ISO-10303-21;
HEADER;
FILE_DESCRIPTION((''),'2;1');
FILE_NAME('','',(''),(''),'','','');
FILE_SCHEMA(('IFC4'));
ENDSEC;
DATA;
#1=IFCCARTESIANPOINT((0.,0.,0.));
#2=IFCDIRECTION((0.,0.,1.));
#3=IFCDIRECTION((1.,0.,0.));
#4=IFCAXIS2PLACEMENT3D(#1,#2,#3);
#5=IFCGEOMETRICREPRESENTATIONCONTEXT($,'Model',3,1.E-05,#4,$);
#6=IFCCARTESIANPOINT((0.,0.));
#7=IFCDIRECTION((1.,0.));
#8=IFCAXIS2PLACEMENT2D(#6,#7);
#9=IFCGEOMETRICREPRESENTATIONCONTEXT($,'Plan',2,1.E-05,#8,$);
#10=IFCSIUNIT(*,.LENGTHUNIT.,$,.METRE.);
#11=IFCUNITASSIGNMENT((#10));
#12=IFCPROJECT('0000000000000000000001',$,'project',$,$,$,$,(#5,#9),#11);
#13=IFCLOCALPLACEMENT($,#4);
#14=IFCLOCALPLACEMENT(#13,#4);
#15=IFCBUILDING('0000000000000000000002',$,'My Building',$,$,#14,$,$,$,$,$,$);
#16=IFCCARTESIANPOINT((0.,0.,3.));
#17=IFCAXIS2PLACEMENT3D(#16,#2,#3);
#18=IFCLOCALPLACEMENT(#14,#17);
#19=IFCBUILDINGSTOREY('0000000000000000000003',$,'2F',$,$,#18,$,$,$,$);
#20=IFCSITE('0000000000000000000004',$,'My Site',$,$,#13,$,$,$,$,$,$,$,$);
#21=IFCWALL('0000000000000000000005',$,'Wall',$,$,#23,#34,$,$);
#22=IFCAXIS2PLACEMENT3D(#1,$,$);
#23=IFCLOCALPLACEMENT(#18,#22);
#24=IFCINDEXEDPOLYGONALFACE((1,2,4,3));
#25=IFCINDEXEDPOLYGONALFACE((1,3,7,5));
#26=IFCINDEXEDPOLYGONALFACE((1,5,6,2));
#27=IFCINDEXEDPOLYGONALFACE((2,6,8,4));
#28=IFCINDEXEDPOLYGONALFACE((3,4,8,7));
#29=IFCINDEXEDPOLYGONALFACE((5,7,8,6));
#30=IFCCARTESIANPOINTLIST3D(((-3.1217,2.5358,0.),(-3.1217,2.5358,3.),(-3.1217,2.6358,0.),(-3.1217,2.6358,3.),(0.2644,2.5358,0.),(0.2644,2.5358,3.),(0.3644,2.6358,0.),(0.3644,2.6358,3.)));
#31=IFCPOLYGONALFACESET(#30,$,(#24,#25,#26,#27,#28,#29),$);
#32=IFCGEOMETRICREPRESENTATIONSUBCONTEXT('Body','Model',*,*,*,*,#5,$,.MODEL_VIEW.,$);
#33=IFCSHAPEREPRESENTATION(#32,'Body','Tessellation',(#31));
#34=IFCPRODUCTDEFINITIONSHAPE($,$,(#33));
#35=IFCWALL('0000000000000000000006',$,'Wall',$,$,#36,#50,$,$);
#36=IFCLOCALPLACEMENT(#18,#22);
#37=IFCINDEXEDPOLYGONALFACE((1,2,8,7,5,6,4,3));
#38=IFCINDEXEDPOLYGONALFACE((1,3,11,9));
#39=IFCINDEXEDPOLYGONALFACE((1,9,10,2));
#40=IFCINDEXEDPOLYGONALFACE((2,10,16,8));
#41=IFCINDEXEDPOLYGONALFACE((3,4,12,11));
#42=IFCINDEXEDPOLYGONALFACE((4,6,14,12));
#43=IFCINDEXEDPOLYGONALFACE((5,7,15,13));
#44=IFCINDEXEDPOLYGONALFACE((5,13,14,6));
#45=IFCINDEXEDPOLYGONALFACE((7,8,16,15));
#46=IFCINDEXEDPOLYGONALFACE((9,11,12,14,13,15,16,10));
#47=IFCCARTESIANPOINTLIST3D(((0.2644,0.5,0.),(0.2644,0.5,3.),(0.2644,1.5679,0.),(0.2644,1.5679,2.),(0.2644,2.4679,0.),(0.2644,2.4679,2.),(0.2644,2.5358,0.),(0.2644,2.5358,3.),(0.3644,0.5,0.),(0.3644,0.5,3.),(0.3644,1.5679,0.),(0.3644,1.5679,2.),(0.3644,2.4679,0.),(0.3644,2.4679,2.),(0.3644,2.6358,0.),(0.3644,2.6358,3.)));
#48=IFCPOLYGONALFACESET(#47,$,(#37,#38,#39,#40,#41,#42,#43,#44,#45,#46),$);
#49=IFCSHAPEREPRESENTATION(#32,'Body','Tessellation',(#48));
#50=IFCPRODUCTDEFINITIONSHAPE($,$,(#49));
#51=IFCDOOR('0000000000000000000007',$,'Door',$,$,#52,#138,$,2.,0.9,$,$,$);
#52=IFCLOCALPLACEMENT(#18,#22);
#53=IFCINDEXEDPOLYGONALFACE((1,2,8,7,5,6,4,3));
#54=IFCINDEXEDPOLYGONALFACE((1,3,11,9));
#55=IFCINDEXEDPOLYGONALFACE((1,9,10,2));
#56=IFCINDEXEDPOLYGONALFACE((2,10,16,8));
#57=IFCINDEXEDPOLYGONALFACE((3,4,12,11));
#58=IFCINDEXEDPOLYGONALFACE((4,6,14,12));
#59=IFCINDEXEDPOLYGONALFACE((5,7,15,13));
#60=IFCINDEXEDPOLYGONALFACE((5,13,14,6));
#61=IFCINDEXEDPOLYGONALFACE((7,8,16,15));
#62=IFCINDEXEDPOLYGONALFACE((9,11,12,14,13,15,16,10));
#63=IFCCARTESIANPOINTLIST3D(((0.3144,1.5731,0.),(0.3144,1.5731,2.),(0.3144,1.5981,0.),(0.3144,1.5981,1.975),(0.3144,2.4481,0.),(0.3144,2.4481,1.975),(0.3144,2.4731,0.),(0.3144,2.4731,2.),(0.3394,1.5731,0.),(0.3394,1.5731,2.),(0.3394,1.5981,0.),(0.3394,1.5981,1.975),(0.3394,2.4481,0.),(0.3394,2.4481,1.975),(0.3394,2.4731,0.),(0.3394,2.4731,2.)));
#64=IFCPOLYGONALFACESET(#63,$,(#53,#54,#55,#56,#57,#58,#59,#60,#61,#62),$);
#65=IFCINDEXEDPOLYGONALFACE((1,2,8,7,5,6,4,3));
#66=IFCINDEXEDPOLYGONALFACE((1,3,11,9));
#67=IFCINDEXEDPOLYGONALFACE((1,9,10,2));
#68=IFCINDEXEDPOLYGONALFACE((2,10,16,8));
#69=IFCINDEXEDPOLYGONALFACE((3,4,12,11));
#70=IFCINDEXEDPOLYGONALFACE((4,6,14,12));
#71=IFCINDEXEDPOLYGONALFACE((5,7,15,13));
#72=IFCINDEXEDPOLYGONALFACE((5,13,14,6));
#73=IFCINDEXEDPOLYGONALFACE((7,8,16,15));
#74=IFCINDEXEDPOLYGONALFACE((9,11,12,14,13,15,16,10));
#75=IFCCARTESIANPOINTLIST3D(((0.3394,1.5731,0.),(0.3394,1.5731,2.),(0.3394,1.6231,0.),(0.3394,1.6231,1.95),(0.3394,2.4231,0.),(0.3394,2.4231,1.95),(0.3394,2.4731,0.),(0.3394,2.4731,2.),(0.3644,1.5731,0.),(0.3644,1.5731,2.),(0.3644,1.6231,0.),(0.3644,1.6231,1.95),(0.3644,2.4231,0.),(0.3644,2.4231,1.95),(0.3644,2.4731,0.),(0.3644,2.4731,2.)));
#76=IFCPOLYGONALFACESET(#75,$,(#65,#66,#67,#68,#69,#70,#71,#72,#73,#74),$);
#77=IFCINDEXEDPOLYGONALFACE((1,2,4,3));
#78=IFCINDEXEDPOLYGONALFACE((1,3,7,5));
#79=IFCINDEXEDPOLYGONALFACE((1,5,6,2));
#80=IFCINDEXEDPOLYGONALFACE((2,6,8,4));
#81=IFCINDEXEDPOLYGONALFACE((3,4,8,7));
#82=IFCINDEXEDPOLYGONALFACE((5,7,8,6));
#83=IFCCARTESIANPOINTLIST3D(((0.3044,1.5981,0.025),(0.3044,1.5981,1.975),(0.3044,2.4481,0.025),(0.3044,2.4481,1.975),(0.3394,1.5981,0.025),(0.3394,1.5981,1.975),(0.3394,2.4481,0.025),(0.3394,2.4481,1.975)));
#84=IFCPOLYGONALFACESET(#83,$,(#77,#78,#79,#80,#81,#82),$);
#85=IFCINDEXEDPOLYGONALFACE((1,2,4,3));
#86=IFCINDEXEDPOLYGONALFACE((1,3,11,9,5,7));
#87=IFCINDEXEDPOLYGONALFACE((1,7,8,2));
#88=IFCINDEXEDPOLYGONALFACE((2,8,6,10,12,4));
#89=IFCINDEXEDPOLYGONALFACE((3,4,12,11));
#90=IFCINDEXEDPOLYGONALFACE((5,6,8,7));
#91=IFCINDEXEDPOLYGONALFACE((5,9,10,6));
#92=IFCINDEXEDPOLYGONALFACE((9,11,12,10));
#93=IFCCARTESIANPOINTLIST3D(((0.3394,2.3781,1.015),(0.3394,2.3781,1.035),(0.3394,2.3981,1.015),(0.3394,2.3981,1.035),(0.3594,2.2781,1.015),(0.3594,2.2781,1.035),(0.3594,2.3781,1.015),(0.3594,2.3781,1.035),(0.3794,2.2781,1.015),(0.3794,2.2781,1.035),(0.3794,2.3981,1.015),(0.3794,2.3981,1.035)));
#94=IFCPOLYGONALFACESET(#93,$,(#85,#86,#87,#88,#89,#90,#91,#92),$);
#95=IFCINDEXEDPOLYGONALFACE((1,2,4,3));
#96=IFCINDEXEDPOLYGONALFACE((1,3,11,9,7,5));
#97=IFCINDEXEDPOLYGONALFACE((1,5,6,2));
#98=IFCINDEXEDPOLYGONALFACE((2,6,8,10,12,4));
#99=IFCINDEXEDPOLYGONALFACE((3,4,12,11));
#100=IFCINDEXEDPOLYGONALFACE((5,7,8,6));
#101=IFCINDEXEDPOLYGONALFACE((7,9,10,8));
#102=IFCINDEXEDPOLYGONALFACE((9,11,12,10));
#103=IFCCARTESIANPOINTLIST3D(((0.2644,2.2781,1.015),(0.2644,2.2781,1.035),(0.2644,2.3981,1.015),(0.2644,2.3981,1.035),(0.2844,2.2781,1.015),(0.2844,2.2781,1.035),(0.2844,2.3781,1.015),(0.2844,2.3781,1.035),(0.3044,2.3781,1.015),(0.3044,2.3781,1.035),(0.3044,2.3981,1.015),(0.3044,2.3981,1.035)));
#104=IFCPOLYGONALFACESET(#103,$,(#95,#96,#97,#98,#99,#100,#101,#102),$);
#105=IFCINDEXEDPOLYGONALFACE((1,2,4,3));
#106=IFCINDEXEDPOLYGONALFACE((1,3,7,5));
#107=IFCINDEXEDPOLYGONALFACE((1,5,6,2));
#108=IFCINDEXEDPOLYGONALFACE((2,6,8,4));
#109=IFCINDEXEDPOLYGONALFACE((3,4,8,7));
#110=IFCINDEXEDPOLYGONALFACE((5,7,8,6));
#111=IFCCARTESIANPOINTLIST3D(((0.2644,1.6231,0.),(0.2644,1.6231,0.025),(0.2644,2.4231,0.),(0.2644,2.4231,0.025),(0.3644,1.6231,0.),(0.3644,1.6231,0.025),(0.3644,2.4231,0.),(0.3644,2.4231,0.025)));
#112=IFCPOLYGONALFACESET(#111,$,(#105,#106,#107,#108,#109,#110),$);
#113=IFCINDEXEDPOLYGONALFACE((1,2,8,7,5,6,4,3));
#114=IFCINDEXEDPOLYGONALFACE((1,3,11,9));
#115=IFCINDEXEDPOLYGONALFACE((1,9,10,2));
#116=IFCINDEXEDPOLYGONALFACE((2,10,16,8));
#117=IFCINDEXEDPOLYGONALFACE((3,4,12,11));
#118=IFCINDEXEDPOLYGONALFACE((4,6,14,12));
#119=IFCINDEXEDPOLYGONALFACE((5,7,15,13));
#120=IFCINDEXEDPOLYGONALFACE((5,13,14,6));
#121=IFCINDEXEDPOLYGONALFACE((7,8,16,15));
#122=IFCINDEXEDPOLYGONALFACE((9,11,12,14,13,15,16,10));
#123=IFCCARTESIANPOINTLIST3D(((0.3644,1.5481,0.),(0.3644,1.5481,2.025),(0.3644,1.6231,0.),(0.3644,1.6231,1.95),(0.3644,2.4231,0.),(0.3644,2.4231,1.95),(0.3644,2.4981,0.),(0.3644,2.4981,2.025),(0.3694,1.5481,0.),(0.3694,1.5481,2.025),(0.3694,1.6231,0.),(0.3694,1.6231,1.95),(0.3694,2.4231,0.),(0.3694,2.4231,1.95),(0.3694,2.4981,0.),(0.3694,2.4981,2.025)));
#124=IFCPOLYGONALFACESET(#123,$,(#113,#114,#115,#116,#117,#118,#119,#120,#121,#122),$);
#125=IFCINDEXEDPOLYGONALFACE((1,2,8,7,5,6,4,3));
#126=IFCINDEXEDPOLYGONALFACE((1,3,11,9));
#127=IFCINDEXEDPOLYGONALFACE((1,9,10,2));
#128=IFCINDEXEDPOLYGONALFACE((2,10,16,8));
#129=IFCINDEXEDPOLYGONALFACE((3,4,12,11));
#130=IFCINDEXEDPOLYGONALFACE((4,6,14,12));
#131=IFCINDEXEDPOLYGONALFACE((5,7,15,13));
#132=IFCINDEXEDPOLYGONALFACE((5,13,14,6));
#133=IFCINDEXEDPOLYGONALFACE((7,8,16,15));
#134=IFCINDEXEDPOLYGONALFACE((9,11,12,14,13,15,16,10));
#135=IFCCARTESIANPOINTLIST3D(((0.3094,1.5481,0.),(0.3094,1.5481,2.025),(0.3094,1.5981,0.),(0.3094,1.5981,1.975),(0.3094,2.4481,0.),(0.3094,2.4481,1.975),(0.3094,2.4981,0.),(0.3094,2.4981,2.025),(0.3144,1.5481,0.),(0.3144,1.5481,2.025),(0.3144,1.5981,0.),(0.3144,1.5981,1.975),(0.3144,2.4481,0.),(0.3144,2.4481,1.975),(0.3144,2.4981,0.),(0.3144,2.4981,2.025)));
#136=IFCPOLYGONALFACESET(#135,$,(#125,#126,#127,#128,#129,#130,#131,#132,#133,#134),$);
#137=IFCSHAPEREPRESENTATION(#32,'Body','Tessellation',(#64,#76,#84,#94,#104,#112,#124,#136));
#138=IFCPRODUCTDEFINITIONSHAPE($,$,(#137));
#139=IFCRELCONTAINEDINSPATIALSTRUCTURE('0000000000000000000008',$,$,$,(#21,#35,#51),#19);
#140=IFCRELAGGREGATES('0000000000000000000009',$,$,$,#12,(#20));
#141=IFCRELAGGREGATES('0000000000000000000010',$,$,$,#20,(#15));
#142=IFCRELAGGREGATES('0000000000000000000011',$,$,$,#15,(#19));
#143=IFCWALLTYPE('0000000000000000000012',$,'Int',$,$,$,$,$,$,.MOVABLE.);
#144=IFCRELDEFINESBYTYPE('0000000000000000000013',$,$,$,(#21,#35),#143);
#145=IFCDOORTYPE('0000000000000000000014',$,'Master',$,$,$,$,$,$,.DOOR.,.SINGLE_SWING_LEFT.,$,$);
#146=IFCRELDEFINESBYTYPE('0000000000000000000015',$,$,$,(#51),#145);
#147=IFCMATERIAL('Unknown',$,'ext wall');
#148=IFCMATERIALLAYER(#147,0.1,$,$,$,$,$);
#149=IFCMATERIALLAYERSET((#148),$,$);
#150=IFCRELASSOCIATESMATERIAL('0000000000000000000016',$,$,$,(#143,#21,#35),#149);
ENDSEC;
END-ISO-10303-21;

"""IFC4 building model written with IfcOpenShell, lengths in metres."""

from ifc_helpers import new_model, entity, si_unit, frame, origin_with_axes, origin_2d_with_axis, place, context, subcontext, project, spatial, line, indexed_curve, outline, extrude, shape, source, transform, mapped, material, layer, layer_set, layer_usage, type_object, type_shapes, element, fill, save


model = new_model("IFC4")

# Units and contexts
model_context = context("Model", 3, precision=1e-05, world=origin_with_axes())
plan_context = context("Plan", 2, precision=1e-05, world=origin_2d_with_axis())
body_context_1 = subcontext(model_context, "Body", "Model", "MODEL_VIEW")
body_context_2 = subcontext(plan_context, "Body", "Plan", "PLAN_VIEW")
ifc_project = project(units=[si_unit("LENGTHUNIT", "METRE")], contexts=[model_context, plan_context])

# Site, building, storey
site_placement = place(None, origin_with_axes())
site = spatial("IfcSite", under=ifc_project, at=site_placement, Name="My Site")
building_placement = place(site_placement, origin_with_axes())
building = spatial("IfcBuilding", under=site, at=building_placement, Name="My Building")
storey_placement = place(building_placement, frame((0.0, 0.0, 3.0), z_axis=(0.0, 0.0, 1.0), x_axis=(1.0, 0.0, 0.0)))
storey = spatial("IfcBuildingStorey", under=building, at=storey_placement, Name="2F")

# Shared definitions
ifc_material = material(Name="Unknown", Category="ext wall")

# Wall
ifc_layer_1 = layer(ifc_material, 0.1)
ifc_layer_set_1 = layer_set([ifc_layer_1])
ifc_layer_usage_1 = layer_usage(ifc_layer_set_1, "AXIS2", "POSITIVE", 0.0)
wall_type_1 = type_object("IfcWallType", Name="Int", PredefinedType="MOVABLE", material=ifc_layer_set_1)
wall_1_placement = place(storey_placement, frame((-3.1217, 2.5358, 0.0), z_axis=(0.0, 0.0, 1.0), x_axis=(1.0, 0.0, 0.0)))
element("IfcWall", 1, at=wall_1_placement, inside=storey, type_object=wall_type_1, material=ifc_layer_usage_1, Name="Wall", context=body_context_1, shape_type="SweptSolid", body=[
    extrude(outline(indexed_curve([(0.0, 0.0), (0.0, 0.1), (3.4861, 0.1), (3.3861, 0.0)], segments=[line(1, 2, 3, 4, 1)])), origin_with_axes(), (0.0, 0.0, 1.0), 3.0),
])

# Wall, opening, door
ifc_layer_usage_2 = layer_usage(ifc_layer_set_1, "AXIS2", "POSITIVE", 0.0)
wall_2_placement = place(storey_placement, frame((0.2644, 2.5358, 0.0), z_axis=(0.0, 0.0, 1.0), x_axis=(0.0, -1.0, 0.0)))
wall_2 = element("IfcWall", 2, at=wall_2_placement, inside=storey, type_object=wall_type_1, material=ifc_layer_usage_2, Name="Wall", context=body_context_1, shape_type="SweptSolid", body=[
    extrude(outline(indexed_curve([(0.0, 0.0), (-0.1, 0.1), (2.0358, 0.1), (2.0358, 0.0)], segments=[line(1, 2, 3, 4, 1)])), origin_with_axes(), (0.0, 0.0, 1.0), 3.0),
])
shared_shape_1 = source(origin_with_axes(), body_context_1, "Body", "SweptSolid", [
    extrude(outline(indexed_curve([(0.0, 0.0), (0.9, 0.0), (0.9, 2.0), (0.0, 2.0)], segments=[line(1, 2, 3, 4, 1)])), frame((0.0, -0.6, 0.0), z_axis=(0.0, -1.0, 0.0), x_axis=(1.0, 0.0, 0.0)), (0.0, 0.0, -1.0), 1.2),
])
opening_1_placement = place(wall_2_placement, frame((0.9679, 0.1, 0.0), z_axis=(0.0, 0.0, 1.0), x_axis=(-1.0, 0.0, 0.0)))
opening_1 = element("IfcOpeningElement", 3, at=opening_1_placement, cuts=wall_2, PredefinedType="OPENING", context=body_context_1, shape_type="MappedRepresentation", body=[
    mapped(shared_shape_1, transform((0.0, 0.0, 0.0), x_axis=(1.0, 0.0, 0.0), y_axis=(0.0, 1.0, 0.0), z_axis=(0.0, 0.0, 1.0), scale=1.0)),
])
door_type_1 = type_object("IfcDoorType", Name="Master", OperationType="SINGLE_SWING_LEFT", PredefinedType="DOOR")
shared_shape_2 = source(origin_with_axes(), body_context_1, "Body", "SweptSolid", [
    extrude(outline(indexed_curve([(0.0, 0.0), (0.0, 2.0), (0.9, 2.0), (0.9, 0.0), (0.875, 0.0), (0.875, 1.975), (0.025, 1.975), (0.025, 0.0)], segments=[line(1, 2, 3, 4, 5, 6, 7, 8, 1)])), frame((0.0, 0.025, 0.0), z_axis=(0.0, -1.0, 0.0), x_axis=(1.0, 0.0, 0.0)), (0.0, 0.0, -1.0), 0.025),
    extrude(outline(indexed_curve([(0.0, 0.0), (0.0, 2.0), (0.9, 2.0), (0.9, 0.0), (0.85, 0.0), (0.85, 1.95), (0.05, 1.95), (0.05, 0.0)], segments=[line(1, 2, 3, 4, 5, 6, 7, 8, 1)])), frame((0.0, 0.0, 0.0), z_axis=(0.0, -1.0, 0.0), x_axis=(1.0, 0.0, 0.0)), (0.0, 0.0, -1.0), 0.025),
    extrude(outline(indexed_curve([(0.0, 0.0), (0.85, 0.0), (0.85, 0.035), (0.0, 0.035)], segments=[line(1, 2, 3, 4, 1)])), frame((0.025, 0.025, 0.025), z_axis=(0.0, 0.0, 1.0), x_axis=(1.0, 0.0, 0.0)), (0.0, 0.0, 1.0), 1.95),
    extrude(outline(indexed_curve([(0.0, 0.0), (0.0, -0.04), (-0.12, -0.04), (-0.12, -0.02), (-0.02, -0.02), (-0.02, 0.0)], segments=[line(1, 2, 3, 4, 5, 6, 1)])), frame((0.825, 0.025, 1.015), z_axis=(0.0, 0.0, 1.0), x_axis=(1.0, 0.0, 0.0)), (0.0, 0.0, 1.0), 0.02),
    extrude(outline(indexed_curve([(0.0, 0.0), (0.0, 0.04), (-0.12, 0.04), (-0.12, 0.02), (-0.02, 0.02), (-0.02, 0.0)], segments=[line(1, 2, 3, 4, 5, 6, 1)])), frame((0.825, 0.06, 1.015), z_axis=(0.0, 0.0, 1.0), x_axis=(1.0, 0.0, 0.0)), (0.0, 0.0, 1.0), 0.02),
    extrude(outline(indexed_curve([(0.0, 0.0), (0.8, 0.0), (0.8, 0.1), (0.0, 0.1)], segments=[line(1, 2, 3, 4, 1)])), frame((0.05, 0.0, 0.0), z_axis=(0.0, 0.0, 1.0), x_axis=(1.0, 0.0, 0.0)), (0.0, 0.0, 1.0), 0.025),
    extrude(outline(indexed_curve([(0.0, 0.0), (0.0, 2.025), (0.95, 2.025), (0.95, 0.0), (0.875, 0.0), (0.875, 1.95), (0.075, 1.95), (0.075, 0.0)], segments=[line(1, 2, 3, 4, 5, 6, 7, 8, 1)])), frame((-0.025, -0.005, 0.0), z_axis=(0.0, -1.0, 0.0), x_axis=(1.0, 0.0, 0.0)), (0.0, 0.0, -1.0), 0.005),
    extrude(outline(indexed_curve([(0.0, 0.0), (0.0, 2.025), (0.95, 2.025), (0.95, 0.0), (0.9, 0.0), (0.9, 1.975), (0.05, 1.975), (0.05, 0.0)], segments=[line(1, 2, 3, 4, 5, 6, 7, 8, 1)])), frame((-0.025, 0.05, 0.0), z_axis=(0.0, -1.0, 0.0), x_axis=(1.0, 0.0, 0.0)), (0.0, 0.0, -1.0), 0.005),
])
shared_shape_3 = source(origin_with_axes(), body_context_2, "Body", "Curve2D", [
    entity("IfcIndexedPolyCurve", entity("IfcCartesianPointList2D", [[0.0, 0.0], [0.0, 0.05], [0.025, 0.05], [0.025, 0.025], [0.05, 0.025], [0.05, 0.0]]), [entity("IfcLineIndex", [1, 2, 3, 4, 5, 6, 1])]),
    entity("IfcIndexedPolyCurve", entity("IfcCartesianPointList2D", [[0.9, 0.0], [0.9, 0.05], [0.875, 0.05], [0.875, 0.025], [0.85, 0.025], [0.85, 0.0]]), [entity("IfcLineIndex", [1, 2, 3, 4, 5, 6, 1])]),
    entity("IfcTrimmedCurve", entity("IfcEllipse", entity("IfcAxis2Placement2D", entity("IfcCartesianPoint", [0.06, 0.05]), entity("IfcDirection", [1.0, 0.0])), 0.815, 0.85), [entity("IfcCartesianPoint", [0.875, 0.05])], [entity("IfcCartesianPoint", [0.06, 0.9])], True, "CARTESIAN"),
    entity("IfcIndexedPolyCurve", entity("IfcCartesianPointList2D", [[0.025, 0.05], [0.06, 0.05], [0.06, 0.9], [0.025, 0.9]]), [entity("IfcLineIndex", [1, 2, 3, 4, 1])]),
])
type_shapes(door_type_1, [shared_shape_2, shared_shape_3])
door_1_placement = place(opening_1_placement, frame((0.0052, 0.0, 0.0), z_axis=(0.0, 0.0, 1.0), x_axis=(1.0, 0.0, 0.0)))
door_1 = element("IfcDoor", 4, at=door_1_placement, inside=storey, type_object=door_type_1, Name="Door", OverallHeight=2.0, OverallWidth=0.9, shapes=[
    shape(body_context_1, "Body", "MappedRepresentation", [mapped(shared_shape_2, transform((0.0, 0.0, 0.0), x_axis=(1.0, 0.0, 0.0), y_axis=(0.0, 1.0, 0.0), z_axis=(0.0, 0.0, 1.0), scale=1.0))]),
    shape(body_context_2, "Body", "MappedRepresentation", [mapped(shared_shape_3, transform((0.0, 0.0, 0.0), x_axis=(1.0, 0.0, 0.0), y_axis=(0.0, 1.0, 0.0), z_axis=(0.0, 0.0, 1.0), scale=1.0))]),
])
fill(opening_1, door_1)

save(model, "model.ifc")
